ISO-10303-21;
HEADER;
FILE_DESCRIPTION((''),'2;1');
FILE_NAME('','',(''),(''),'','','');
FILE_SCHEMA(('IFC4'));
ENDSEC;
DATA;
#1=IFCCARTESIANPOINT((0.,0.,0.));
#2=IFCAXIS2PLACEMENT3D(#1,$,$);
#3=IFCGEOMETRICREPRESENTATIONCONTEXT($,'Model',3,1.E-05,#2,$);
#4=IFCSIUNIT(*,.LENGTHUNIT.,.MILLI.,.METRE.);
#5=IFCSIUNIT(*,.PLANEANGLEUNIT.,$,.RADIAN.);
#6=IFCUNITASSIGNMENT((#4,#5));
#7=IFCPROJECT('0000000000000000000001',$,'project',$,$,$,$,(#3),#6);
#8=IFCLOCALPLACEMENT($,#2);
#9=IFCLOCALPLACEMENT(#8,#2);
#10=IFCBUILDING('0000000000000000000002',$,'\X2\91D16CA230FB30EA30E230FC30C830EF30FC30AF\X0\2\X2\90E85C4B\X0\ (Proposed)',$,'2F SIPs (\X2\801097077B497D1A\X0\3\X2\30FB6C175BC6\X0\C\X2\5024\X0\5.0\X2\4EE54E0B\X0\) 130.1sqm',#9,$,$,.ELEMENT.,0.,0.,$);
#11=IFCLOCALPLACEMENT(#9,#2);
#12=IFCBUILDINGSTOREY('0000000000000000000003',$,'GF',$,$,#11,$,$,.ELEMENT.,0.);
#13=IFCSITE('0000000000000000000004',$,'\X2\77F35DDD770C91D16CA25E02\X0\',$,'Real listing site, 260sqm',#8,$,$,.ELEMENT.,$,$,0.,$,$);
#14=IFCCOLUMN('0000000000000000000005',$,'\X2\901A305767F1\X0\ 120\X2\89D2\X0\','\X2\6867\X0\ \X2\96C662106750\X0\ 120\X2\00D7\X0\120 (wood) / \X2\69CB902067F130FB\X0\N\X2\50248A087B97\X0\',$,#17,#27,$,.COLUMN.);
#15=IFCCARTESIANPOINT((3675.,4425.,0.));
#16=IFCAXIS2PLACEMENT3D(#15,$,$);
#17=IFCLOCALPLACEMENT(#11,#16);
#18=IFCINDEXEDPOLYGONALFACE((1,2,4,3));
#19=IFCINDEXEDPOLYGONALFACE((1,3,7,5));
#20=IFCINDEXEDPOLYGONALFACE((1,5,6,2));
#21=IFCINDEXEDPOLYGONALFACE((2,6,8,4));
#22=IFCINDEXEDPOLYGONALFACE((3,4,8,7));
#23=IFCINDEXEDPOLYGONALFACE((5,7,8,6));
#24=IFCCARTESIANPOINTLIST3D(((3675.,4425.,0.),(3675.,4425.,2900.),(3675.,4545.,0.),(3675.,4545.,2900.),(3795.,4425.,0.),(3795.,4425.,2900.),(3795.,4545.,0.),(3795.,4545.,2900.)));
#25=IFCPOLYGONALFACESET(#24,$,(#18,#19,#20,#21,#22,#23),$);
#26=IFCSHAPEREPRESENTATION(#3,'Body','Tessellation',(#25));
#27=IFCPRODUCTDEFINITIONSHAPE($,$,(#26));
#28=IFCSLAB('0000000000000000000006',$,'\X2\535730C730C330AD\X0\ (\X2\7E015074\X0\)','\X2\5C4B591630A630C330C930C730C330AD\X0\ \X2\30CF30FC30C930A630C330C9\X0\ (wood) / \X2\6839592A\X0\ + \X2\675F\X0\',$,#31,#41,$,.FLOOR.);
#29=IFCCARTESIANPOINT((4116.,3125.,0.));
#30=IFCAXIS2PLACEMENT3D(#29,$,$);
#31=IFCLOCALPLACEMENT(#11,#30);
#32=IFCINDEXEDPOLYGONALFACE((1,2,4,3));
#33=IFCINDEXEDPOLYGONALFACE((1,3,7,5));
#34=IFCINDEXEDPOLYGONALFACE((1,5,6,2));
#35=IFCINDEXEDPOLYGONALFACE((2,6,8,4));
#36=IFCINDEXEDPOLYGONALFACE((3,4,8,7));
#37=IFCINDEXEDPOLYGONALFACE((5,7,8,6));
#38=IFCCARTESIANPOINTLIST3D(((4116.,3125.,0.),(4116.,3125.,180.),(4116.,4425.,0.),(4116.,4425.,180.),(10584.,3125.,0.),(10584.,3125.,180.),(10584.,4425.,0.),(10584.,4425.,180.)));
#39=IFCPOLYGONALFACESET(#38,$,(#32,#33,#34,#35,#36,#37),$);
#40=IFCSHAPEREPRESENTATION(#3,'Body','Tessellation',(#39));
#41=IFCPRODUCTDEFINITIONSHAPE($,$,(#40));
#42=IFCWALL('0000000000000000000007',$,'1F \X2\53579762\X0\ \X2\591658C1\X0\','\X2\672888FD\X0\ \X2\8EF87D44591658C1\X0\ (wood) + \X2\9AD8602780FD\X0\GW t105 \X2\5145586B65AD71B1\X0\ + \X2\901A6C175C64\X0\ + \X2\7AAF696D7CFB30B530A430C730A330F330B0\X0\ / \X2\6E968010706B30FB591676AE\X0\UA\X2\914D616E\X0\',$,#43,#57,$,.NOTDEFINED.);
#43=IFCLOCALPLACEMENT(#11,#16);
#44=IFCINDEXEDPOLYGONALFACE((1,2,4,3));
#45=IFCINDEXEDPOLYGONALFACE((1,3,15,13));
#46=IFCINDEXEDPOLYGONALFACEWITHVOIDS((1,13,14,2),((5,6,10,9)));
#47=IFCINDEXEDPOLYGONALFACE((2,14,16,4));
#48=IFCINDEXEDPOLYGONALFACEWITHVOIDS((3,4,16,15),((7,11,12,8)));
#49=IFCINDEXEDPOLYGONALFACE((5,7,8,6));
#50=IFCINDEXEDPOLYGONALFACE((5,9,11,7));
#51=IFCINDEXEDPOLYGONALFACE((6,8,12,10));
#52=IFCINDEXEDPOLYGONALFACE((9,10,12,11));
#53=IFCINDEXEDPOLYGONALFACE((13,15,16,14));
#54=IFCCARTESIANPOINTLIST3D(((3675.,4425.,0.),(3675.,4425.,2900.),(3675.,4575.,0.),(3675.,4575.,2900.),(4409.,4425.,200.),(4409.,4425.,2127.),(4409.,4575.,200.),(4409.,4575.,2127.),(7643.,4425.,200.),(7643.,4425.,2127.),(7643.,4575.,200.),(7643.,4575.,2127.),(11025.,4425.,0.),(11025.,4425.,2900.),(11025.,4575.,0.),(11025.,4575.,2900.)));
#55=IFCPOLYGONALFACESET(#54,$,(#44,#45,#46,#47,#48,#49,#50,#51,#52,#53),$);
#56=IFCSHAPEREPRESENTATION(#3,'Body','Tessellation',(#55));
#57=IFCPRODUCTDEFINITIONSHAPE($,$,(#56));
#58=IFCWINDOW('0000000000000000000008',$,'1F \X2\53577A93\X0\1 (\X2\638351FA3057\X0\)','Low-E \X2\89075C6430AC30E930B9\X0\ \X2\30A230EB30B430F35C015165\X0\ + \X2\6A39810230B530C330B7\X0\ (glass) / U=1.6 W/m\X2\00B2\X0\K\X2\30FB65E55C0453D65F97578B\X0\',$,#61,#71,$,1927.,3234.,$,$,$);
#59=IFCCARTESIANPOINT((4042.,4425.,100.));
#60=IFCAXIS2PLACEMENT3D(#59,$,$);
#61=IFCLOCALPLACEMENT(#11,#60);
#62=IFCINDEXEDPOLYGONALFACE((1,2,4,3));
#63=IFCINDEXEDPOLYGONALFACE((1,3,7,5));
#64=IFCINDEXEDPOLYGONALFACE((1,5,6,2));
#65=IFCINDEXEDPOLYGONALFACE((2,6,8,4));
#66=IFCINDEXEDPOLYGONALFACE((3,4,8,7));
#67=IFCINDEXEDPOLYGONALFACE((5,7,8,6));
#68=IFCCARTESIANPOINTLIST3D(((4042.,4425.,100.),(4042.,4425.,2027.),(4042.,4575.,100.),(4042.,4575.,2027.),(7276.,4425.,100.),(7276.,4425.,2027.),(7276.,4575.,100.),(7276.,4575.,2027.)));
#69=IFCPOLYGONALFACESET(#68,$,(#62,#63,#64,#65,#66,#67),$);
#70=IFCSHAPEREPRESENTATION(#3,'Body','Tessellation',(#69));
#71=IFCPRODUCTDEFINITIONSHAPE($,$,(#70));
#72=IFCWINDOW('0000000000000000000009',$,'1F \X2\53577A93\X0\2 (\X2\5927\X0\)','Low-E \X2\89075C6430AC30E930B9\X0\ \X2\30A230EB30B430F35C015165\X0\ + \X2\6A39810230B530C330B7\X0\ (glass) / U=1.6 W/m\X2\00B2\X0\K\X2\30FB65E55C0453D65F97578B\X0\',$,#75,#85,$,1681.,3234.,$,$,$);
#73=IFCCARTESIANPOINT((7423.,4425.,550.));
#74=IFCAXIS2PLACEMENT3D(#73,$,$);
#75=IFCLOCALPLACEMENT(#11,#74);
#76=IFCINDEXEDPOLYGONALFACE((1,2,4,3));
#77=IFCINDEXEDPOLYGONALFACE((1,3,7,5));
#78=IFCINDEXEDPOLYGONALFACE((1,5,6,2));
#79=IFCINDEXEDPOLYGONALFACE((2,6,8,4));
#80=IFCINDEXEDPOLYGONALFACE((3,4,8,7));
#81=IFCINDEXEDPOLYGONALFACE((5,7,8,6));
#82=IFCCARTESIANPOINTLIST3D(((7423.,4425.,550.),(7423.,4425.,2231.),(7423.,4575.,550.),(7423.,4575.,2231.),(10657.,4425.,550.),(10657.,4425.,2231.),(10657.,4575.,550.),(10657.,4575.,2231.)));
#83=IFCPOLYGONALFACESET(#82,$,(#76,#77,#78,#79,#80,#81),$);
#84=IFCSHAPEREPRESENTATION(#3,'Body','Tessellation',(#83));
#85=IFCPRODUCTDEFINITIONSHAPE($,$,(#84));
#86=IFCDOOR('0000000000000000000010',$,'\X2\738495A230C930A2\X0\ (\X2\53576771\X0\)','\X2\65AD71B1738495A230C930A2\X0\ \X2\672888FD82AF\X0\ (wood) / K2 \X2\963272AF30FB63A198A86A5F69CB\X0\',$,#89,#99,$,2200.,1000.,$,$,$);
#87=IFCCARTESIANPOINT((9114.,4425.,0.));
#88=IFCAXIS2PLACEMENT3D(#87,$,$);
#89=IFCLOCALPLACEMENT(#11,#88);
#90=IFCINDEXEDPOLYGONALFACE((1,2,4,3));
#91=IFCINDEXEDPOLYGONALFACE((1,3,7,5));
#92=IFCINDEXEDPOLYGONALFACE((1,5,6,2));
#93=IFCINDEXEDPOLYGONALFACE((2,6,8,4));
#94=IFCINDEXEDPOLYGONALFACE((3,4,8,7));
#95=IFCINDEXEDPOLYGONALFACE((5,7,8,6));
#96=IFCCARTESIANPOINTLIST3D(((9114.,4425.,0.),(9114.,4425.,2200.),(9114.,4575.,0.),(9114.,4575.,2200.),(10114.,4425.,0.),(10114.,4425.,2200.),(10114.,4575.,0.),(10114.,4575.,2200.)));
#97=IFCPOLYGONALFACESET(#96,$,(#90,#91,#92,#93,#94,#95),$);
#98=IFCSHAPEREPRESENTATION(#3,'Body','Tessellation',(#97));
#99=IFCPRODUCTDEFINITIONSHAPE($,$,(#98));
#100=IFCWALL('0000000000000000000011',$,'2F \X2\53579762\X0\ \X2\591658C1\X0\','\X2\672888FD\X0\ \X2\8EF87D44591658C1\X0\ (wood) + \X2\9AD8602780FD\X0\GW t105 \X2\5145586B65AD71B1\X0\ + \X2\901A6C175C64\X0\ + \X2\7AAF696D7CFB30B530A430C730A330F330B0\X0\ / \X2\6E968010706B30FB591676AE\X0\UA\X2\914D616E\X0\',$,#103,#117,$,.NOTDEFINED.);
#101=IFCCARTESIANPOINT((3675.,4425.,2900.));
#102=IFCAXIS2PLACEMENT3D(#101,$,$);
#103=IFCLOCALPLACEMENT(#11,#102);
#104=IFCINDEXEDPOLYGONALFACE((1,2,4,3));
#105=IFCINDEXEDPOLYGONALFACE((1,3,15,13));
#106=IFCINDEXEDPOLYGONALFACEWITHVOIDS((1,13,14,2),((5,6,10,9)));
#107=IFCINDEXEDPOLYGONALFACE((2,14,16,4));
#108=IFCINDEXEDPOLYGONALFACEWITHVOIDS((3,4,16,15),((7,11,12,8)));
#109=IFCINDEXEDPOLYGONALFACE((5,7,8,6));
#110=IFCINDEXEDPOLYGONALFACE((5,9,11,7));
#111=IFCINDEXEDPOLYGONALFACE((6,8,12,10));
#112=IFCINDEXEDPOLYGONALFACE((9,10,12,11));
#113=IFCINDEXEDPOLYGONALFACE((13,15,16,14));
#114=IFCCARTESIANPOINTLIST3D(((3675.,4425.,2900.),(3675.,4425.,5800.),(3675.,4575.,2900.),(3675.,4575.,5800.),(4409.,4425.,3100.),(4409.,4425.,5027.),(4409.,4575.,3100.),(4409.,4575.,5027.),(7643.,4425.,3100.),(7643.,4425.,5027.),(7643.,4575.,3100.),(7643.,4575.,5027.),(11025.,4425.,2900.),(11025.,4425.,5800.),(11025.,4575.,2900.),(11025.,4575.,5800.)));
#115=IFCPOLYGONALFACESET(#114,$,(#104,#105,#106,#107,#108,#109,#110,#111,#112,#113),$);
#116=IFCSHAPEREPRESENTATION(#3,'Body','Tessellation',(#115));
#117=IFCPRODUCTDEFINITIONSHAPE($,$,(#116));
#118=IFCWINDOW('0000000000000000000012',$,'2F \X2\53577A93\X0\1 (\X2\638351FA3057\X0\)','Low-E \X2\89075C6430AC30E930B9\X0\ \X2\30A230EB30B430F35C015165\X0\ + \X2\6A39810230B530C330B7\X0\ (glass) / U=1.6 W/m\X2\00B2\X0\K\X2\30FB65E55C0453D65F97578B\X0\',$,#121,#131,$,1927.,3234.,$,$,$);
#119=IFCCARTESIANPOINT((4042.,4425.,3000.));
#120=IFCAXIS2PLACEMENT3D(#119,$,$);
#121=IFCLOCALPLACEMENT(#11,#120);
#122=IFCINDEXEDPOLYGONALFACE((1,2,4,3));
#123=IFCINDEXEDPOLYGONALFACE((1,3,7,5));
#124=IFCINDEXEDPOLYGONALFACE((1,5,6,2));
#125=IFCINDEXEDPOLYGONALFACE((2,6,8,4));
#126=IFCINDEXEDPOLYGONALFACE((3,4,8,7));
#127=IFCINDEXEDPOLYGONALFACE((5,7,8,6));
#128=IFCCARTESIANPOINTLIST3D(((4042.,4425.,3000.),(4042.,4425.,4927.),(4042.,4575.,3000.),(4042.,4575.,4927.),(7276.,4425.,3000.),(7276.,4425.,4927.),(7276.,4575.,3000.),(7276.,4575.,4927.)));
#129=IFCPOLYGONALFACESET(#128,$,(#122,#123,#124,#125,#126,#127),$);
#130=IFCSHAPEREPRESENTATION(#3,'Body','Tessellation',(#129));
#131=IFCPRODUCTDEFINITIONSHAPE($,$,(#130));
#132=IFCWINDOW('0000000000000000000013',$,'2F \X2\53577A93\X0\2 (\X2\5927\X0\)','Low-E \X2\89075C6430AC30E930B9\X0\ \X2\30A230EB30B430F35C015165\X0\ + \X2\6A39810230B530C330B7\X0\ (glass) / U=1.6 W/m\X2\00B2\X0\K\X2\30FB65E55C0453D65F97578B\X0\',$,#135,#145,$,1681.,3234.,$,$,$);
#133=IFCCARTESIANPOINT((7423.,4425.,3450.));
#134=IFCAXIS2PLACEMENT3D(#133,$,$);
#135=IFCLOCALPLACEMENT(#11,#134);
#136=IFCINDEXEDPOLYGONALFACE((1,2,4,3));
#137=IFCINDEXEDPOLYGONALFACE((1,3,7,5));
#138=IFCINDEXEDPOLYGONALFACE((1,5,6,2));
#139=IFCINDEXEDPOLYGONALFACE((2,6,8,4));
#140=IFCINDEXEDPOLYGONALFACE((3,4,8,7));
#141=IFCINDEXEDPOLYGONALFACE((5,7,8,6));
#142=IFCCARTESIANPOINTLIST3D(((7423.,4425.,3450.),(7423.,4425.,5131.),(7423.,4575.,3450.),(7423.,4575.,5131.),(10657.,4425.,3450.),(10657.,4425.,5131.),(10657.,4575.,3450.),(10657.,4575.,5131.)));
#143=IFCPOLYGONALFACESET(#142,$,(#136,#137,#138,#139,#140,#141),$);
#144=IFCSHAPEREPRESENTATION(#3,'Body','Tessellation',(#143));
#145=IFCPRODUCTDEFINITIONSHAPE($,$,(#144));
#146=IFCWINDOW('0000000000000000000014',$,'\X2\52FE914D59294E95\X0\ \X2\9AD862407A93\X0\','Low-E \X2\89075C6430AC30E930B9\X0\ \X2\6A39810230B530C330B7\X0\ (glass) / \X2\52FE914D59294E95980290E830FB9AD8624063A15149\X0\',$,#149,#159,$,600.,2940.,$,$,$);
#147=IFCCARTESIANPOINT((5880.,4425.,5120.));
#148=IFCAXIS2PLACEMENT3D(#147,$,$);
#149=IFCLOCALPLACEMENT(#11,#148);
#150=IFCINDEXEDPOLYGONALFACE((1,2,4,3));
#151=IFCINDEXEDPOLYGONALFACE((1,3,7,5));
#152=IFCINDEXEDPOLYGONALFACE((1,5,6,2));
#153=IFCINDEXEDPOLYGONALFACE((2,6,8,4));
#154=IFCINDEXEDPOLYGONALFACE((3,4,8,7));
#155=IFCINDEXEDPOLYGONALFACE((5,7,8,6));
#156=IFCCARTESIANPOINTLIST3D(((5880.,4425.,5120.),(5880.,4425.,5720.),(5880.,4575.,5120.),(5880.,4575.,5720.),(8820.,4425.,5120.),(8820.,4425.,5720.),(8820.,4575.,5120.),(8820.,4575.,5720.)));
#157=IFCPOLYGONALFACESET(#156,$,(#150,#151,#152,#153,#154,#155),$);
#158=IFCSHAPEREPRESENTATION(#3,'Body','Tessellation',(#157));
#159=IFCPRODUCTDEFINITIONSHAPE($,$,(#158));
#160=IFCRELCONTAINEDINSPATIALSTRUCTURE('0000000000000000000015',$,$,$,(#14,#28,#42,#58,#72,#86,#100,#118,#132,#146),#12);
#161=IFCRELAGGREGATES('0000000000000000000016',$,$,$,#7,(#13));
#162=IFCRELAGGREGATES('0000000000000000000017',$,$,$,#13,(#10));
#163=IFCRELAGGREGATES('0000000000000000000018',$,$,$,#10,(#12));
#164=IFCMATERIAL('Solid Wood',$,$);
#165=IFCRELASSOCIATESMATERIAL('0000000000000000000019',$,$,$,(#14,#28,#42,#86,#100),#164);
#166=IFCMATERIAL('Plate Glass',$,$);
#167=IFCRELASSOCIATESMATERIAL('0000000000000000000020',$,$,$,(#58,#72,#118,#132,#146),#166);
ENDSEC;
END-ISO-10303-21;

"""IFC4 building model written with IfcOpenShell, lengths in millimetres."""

from ifc_helpers import new_model, si_unit, frame, frame_2d, origin, place, context, project, spatial, rectangle, extrude, material, element, fill, save


model = new_model("IFC4")

# Units and contexts
model_context = context("Model", 3, precision=1e-05, world=origin())
ifc_project = project(units=[si_unit("LENGTHUNIT", "METRE", prefix="MILLI"), si_unit("PLANEANGLEUNIT", "RADIAN")], contexts=[model_context])

# Site, building, storey
site_placement = place(None, origin())
site = spatial("IfcSite", under=ifc_project, at=site_placement, Name="石川県金沢市", ObjectType="Real listing site, 260sqm", CompositionType="ELEMENT", RefElevation=0.0)
building_placement = place(site_placement, origin())
building = spatial("IfcBuilding", under=site, at=building_placement, Name="金沢・リモートワーク2部屋 (Proposed)", ObjectType="2F SIPs (耐震等級3・気密C値5.0以下) 130.1sqm", CompositionType="ELEMENT", ElevationOfRefHeight=0.0, ElevationOfTerrain=0.0)
storey_placement = place(building_placement, origin())
storey = spatial("IfcBuildingStorey", under=building, at=storey_placement, Name="GF", CompositionType="ELEMENT", Elevation=0.0)

# Column
ifc_material_1 = material(Name="Solid Wood")
column_placement = place(storey_placement, frame((3675.0, 4425.0, 0.0)))
element("IfcColumn", 1, at=column_placement, inside=storey, material=ifc_material_1, Name="通し柱 120角", Description="桧 集成材 120×120 (wood) / 構造柱・N値計算", PredefinedType="COLUMN", context=model_context, shape_type="SweptSolid", body=[
    extrude(rectangle(XDim=120.0, YDim=120.0, at=frame_2d((60.0, 60.0))), frame((3675.0, 4425.0, 0.0)), (0.0, 0.0, 1.0), 2900.0),
])

# Slab
slab_1_placement = place(storey_placement, frame((4116.0, 3125.0, 0.0)))
element("IfcSlab", 2, at=slab_1_placement, inside=storey, material=ifc_material_1, Name="南デッキ (縁側)", Description="屋外ウッドデッキ ハードウッド (wood) / 根太 + 束", PredefinedType="FLOOR", context=model_context, shape_type="SweptSolid", body=[
    extrude(rectangle(XDim=6468.0, YDim=1300.0, at=frame_2d((3234.0, 650.0))), frame((4116.0, 3125.0, 0.0)), (0.0, 0.0, 1.0), 180.0),
])

# Wall, openings, windows, door
wall_1_placement = place(storey_placement, frame((3675.0, 4425.0, 0.0)))
wall_1 = element("IfcWall", 3, at=wall_1_placement, inside=storey, material=ifc_material_1, Name="1F 南面 外壁", Description="木製 軸組外壁 (wood) + 高性能GW t105 充填断熱 + 通気層 + 窯業系サイディング / 準耐火・外皮UA配慮", PredefinedType="NOTDEFINED", context=model_context, shape_type="SweptSolid", body=[
    extrude(rectangle(XDim=7350.0, YDim=150.0, at=frame_2d((3675.0, 75.0))), frame((3675.0, 4425.0, 0.0)), (0.0, 0.0, 1.0), 2900.0),
])
opening_1_placement = place(storey_placement, frame((4042.0, 4425.0, 100.0)))
opening_1 = element("IfcOpeningElement", 4, at=opening_1_placement, cuts=wall_1, PredefinedType="NOTDEFINED", context=model_context, shape_type="SweptSolid", body=[
    extrude(rectangle(XDim=3234.0, YDim=150.0, at=frame_2d((1617.0, 75.0))), frame((4042.0, 4425.0, 100.0)), (0.0, 0.0, 1.0), 1927.0),
])
opening_2_placement = place(storey_placement, frame((7423.0, 4425.0, 550.0)))
opening_2 = element("IfcOpeningElement", 5, at=opening_2_placement, cuts=wall_1, PredefinedType="NOTDEFINED", context=model_context, shape_type="SweptSolid", body=[
    extrude(rectangle(XDim=3234.0, YDim=150.0, at=frame_2d((1617.0, 75.0))), frame((7423.0, 4425.0, 550.0)), (0.0, 0.0, 1.0), 1681.0),
])
opening_3_placement = place(storey_placement, frame((9114.0, 4425.0, 0.0)))
opening_3 = element("IfcOpeningElement", 6, at=opening_3_placement, cuts=wall_1, PredefinedType="NOTDEFINED", context=model_context, shape_type="SweptSolid", body=[
    extrude(rectangle(XDim=1000.0, YDim=150.0, at=frame_2d((500.0, 75.0))), frame((9114.0, 4425.0, 0.0)), (0.0, 0.0, 1.0), 2200.0),
])
ifc_material_2 = material(Name="Plate Glass")
window_1_placement = place(storey_placement, frame((4042.0, 4425.0, 100.0)))
window_1 = element("IfcWindow", 7, at=window_1_placement, inside=storey, material=ifc_material_2, Name="1F 南窓1 (掃出し)", Description="Low-E 複層ガラス アルゴン封入 + 樹脂サッシ (glass) / U=1.6 W/m²K・日射取得型", OverallHeight=1927.0, OverallWidth=3234.0, context=model_context, shape_type="SweptSolid", body=[
    extrude(rectangle(XDim=3234.0, YDim=150.0, at=frame_2d((1617.0, 75.0))), frame((4042.0, 4425.0, 100.0)), (0.0, 0.0, 1.0), 1927.0),
])
fill(opening_1, window_1)
window_2_placement = place(storey_placement, frame((7423.0, 4425.0, 550.0)))
window_2 = element("IfcWindow", 8, at=window_2_placement, inside=storey, material=ifc_material_2, Name="1F 南窓2 (大)", Description="Low-E 複層ガラス アルゴン封入 + 樹脂サッシ (glass) / U=1.6 W/m²K・日射取得型", OverallHeight=1681.0, OverallWidth=3234.0, context=model_context, shape_type="SweptSolid", body=[
    extrude(rectangle(XDim=3234.0, YDim=150.0, at=frame_2d((1617.0, 75.0))), frame((7423.0, 4425.0, 550.0)), (0.0, 0.0, 1.0), 1681.0),
])
fill(opening_2, window_2)
door_placement = place(storey_placement, frame((9114.0, 4425.0, 0.0)))
door = element("IfcDoor", 9, at=door_placement, inside=storey, material=ifc_material_1, Name="玄関ドア (南東)", Description="断熱玄関ドア 木製芯 (wood) / K2 防犯・採風機構", OverallHeight=2200.0, OverallWidth=1000.0, context=model_context, shape_type="SweptSolid", body=[
    extrude(rectangle(XDim=1000.0, YDim=150.0, at=frame_2d((500.0, 75.0))), frame((9114.0, 4425.0, 0.0)), (0.0, 0.0, 1.0), 2200.0),
])
fill(opening_3, door)

# Wall, openings, windows
wall_2_placement = place(storey_placement, frame((3675.0, 4425.0, 2900.0)))
wall_2 = element("IfcWall", 10, at=wall_2_placement, inside=storey, material=ifc_material_1, Name="2F 南面 外壁", Description="木製 軸組外壁 (wood) + 高性能GW t105 充填断熱 + 通気層 + 窯業系サイディング / 準耐火・外皮UA配慮", PredefinedType="NOTDEFINED", context=model_context, shape_type="SweptSolid", body=[
    extrude(rectangle(XDim=7350.0, YDim=150.0, at=frame_2d((3675.0, 75.0))), frame((3675.0, 4425.0, 2900.0)), (0.0, 0.0, 1.0), 2900.0),
])
opening_4_placement = place(storey_placement, frame((4042.0, 4425.0, 3000.0)))
opening_4 = element("IfcOpeningElement", 11, at=opening_4_placement, cuts=wall_2, PredefinedType="NOTDEFINED", context=model_context, shape_type="SweptSolid", body=[
    extrude(rectangle(XDim=3234.0, YDim=150.0, at=frame_2d((1617.0, 75.0))), frame((4042.0, 4425.0, 3000.0)), (0.0, 0.0, 1.0), 1927.0),
])
opening_5_placement = place(storey_placement, frame((7423.0, 4425.0, 3450.0)))
opening_5 = element("IfcOpeningElement", 12, at=opening_5_placement, cuts=wall_2, PredefinedType="NOTDEFINED", context=model_context, shape_type="SweptSolid", body=[
    extrude(rectangle(XDim=3234.0, YDim=150.0, at=frame_2d((1617.0, 75.0))), frame((7423.0, 4425.0, 3450.0)), (0.0, 0.0, 1.0), 1681.0),
])
opening_6_placement = place(storey_placement, frame((5880.0, 4425.0, 5120.0)))
opening_6 = element("IfcOpeningElement", 13, at=opening_6_placement, cuts=wall_2, PredefinedType="NOTDEFINED", context=model_context, shape_type="SweptSolid", body=[
    extrude(rectangle(XDim=2940.0, YDim=150.0, at=frame_2d((1470.0, 75.0))), frame((5880.0, 4425.0, 5120.0)), (0.0, 0.0, 1.0), 600.0),
])
window_3_placement = place(storey_placement, frame((4042.0, 4425.0, 3000.0)))
window_3 = element("IfcWindow", 14, at=window_3_placement, inside=storey, material=ifc_material_2, Name="2F 南窓1 (掃出し)", Description="Low-E 複層ガラス アルゴン封入 + 樹脂サッシ (glass) / U=1.6 W/m²K・日射取得型", OverallHeight=1927.0, OverallWidth=3234.0, context=model_context, shape_type="SweptSolid", body=[
    extrude(rectangle(XDim=3234.0, YDim=150.0, at=frame_2d((1617.0, 75.0))), frame((4042.0, 4425.0, 3000.0)), (0.0, 0.0, 1.0), 1927.0),
])
fill(opening_4, window_3)
window_4_placement = place(storey_placement, frame((7423.0, 4425.0, 3450.0)))
window_4 = element("IfcWindow", 15, at=window_4_placement, inside=storey, material=ifc_material_2, Name="2F 南窓2 (大)", Description="Low-E 複層ガラス アルゴン封入 + 樹脂サッシ (glass) / U=1.6 W/m²K・日射取得型", OverallHeight=1681.0, OverallWidth=3234.0, context=model_context, shape_type="SweptSolid", body=[
    extrude(rectangle(XDim=3234.0, YDim=150.0, at=frame_2d((1617.0, 75.0))), frame((7423.0, 4425.0, 3450.0)), (0.0, 0.0, 1.0), 1681.0),
])
fill(opening_5, window_4)
window_5_placement = place(storey_placement, frame((5880.0, 4425.0, 5120.0)))
window_5 = element("IfcWindow", 16, at=window_5_placement, inside=storey, material=ifc_material_2, Name="勾配天井 高所窓", Description="Low-E 複層ガラス 樹脂サッシ (glass) / 勾配天井頂部・高所採光", OverallHeight=600.0, OverallWidth=2940.0, context=model_context, shape_type="SweptSolid", body=[
    extrude(rectangle(XDim=2940.0, YDim=150.0, at=frame_2d((1470.0, 75.0))), frame((5880.0, 4425.0, 5120.0)), (0.0, 0.0, 1.0), 600.0),
])
fill(opening_6, window_5)

save(model, "model.ifc")
